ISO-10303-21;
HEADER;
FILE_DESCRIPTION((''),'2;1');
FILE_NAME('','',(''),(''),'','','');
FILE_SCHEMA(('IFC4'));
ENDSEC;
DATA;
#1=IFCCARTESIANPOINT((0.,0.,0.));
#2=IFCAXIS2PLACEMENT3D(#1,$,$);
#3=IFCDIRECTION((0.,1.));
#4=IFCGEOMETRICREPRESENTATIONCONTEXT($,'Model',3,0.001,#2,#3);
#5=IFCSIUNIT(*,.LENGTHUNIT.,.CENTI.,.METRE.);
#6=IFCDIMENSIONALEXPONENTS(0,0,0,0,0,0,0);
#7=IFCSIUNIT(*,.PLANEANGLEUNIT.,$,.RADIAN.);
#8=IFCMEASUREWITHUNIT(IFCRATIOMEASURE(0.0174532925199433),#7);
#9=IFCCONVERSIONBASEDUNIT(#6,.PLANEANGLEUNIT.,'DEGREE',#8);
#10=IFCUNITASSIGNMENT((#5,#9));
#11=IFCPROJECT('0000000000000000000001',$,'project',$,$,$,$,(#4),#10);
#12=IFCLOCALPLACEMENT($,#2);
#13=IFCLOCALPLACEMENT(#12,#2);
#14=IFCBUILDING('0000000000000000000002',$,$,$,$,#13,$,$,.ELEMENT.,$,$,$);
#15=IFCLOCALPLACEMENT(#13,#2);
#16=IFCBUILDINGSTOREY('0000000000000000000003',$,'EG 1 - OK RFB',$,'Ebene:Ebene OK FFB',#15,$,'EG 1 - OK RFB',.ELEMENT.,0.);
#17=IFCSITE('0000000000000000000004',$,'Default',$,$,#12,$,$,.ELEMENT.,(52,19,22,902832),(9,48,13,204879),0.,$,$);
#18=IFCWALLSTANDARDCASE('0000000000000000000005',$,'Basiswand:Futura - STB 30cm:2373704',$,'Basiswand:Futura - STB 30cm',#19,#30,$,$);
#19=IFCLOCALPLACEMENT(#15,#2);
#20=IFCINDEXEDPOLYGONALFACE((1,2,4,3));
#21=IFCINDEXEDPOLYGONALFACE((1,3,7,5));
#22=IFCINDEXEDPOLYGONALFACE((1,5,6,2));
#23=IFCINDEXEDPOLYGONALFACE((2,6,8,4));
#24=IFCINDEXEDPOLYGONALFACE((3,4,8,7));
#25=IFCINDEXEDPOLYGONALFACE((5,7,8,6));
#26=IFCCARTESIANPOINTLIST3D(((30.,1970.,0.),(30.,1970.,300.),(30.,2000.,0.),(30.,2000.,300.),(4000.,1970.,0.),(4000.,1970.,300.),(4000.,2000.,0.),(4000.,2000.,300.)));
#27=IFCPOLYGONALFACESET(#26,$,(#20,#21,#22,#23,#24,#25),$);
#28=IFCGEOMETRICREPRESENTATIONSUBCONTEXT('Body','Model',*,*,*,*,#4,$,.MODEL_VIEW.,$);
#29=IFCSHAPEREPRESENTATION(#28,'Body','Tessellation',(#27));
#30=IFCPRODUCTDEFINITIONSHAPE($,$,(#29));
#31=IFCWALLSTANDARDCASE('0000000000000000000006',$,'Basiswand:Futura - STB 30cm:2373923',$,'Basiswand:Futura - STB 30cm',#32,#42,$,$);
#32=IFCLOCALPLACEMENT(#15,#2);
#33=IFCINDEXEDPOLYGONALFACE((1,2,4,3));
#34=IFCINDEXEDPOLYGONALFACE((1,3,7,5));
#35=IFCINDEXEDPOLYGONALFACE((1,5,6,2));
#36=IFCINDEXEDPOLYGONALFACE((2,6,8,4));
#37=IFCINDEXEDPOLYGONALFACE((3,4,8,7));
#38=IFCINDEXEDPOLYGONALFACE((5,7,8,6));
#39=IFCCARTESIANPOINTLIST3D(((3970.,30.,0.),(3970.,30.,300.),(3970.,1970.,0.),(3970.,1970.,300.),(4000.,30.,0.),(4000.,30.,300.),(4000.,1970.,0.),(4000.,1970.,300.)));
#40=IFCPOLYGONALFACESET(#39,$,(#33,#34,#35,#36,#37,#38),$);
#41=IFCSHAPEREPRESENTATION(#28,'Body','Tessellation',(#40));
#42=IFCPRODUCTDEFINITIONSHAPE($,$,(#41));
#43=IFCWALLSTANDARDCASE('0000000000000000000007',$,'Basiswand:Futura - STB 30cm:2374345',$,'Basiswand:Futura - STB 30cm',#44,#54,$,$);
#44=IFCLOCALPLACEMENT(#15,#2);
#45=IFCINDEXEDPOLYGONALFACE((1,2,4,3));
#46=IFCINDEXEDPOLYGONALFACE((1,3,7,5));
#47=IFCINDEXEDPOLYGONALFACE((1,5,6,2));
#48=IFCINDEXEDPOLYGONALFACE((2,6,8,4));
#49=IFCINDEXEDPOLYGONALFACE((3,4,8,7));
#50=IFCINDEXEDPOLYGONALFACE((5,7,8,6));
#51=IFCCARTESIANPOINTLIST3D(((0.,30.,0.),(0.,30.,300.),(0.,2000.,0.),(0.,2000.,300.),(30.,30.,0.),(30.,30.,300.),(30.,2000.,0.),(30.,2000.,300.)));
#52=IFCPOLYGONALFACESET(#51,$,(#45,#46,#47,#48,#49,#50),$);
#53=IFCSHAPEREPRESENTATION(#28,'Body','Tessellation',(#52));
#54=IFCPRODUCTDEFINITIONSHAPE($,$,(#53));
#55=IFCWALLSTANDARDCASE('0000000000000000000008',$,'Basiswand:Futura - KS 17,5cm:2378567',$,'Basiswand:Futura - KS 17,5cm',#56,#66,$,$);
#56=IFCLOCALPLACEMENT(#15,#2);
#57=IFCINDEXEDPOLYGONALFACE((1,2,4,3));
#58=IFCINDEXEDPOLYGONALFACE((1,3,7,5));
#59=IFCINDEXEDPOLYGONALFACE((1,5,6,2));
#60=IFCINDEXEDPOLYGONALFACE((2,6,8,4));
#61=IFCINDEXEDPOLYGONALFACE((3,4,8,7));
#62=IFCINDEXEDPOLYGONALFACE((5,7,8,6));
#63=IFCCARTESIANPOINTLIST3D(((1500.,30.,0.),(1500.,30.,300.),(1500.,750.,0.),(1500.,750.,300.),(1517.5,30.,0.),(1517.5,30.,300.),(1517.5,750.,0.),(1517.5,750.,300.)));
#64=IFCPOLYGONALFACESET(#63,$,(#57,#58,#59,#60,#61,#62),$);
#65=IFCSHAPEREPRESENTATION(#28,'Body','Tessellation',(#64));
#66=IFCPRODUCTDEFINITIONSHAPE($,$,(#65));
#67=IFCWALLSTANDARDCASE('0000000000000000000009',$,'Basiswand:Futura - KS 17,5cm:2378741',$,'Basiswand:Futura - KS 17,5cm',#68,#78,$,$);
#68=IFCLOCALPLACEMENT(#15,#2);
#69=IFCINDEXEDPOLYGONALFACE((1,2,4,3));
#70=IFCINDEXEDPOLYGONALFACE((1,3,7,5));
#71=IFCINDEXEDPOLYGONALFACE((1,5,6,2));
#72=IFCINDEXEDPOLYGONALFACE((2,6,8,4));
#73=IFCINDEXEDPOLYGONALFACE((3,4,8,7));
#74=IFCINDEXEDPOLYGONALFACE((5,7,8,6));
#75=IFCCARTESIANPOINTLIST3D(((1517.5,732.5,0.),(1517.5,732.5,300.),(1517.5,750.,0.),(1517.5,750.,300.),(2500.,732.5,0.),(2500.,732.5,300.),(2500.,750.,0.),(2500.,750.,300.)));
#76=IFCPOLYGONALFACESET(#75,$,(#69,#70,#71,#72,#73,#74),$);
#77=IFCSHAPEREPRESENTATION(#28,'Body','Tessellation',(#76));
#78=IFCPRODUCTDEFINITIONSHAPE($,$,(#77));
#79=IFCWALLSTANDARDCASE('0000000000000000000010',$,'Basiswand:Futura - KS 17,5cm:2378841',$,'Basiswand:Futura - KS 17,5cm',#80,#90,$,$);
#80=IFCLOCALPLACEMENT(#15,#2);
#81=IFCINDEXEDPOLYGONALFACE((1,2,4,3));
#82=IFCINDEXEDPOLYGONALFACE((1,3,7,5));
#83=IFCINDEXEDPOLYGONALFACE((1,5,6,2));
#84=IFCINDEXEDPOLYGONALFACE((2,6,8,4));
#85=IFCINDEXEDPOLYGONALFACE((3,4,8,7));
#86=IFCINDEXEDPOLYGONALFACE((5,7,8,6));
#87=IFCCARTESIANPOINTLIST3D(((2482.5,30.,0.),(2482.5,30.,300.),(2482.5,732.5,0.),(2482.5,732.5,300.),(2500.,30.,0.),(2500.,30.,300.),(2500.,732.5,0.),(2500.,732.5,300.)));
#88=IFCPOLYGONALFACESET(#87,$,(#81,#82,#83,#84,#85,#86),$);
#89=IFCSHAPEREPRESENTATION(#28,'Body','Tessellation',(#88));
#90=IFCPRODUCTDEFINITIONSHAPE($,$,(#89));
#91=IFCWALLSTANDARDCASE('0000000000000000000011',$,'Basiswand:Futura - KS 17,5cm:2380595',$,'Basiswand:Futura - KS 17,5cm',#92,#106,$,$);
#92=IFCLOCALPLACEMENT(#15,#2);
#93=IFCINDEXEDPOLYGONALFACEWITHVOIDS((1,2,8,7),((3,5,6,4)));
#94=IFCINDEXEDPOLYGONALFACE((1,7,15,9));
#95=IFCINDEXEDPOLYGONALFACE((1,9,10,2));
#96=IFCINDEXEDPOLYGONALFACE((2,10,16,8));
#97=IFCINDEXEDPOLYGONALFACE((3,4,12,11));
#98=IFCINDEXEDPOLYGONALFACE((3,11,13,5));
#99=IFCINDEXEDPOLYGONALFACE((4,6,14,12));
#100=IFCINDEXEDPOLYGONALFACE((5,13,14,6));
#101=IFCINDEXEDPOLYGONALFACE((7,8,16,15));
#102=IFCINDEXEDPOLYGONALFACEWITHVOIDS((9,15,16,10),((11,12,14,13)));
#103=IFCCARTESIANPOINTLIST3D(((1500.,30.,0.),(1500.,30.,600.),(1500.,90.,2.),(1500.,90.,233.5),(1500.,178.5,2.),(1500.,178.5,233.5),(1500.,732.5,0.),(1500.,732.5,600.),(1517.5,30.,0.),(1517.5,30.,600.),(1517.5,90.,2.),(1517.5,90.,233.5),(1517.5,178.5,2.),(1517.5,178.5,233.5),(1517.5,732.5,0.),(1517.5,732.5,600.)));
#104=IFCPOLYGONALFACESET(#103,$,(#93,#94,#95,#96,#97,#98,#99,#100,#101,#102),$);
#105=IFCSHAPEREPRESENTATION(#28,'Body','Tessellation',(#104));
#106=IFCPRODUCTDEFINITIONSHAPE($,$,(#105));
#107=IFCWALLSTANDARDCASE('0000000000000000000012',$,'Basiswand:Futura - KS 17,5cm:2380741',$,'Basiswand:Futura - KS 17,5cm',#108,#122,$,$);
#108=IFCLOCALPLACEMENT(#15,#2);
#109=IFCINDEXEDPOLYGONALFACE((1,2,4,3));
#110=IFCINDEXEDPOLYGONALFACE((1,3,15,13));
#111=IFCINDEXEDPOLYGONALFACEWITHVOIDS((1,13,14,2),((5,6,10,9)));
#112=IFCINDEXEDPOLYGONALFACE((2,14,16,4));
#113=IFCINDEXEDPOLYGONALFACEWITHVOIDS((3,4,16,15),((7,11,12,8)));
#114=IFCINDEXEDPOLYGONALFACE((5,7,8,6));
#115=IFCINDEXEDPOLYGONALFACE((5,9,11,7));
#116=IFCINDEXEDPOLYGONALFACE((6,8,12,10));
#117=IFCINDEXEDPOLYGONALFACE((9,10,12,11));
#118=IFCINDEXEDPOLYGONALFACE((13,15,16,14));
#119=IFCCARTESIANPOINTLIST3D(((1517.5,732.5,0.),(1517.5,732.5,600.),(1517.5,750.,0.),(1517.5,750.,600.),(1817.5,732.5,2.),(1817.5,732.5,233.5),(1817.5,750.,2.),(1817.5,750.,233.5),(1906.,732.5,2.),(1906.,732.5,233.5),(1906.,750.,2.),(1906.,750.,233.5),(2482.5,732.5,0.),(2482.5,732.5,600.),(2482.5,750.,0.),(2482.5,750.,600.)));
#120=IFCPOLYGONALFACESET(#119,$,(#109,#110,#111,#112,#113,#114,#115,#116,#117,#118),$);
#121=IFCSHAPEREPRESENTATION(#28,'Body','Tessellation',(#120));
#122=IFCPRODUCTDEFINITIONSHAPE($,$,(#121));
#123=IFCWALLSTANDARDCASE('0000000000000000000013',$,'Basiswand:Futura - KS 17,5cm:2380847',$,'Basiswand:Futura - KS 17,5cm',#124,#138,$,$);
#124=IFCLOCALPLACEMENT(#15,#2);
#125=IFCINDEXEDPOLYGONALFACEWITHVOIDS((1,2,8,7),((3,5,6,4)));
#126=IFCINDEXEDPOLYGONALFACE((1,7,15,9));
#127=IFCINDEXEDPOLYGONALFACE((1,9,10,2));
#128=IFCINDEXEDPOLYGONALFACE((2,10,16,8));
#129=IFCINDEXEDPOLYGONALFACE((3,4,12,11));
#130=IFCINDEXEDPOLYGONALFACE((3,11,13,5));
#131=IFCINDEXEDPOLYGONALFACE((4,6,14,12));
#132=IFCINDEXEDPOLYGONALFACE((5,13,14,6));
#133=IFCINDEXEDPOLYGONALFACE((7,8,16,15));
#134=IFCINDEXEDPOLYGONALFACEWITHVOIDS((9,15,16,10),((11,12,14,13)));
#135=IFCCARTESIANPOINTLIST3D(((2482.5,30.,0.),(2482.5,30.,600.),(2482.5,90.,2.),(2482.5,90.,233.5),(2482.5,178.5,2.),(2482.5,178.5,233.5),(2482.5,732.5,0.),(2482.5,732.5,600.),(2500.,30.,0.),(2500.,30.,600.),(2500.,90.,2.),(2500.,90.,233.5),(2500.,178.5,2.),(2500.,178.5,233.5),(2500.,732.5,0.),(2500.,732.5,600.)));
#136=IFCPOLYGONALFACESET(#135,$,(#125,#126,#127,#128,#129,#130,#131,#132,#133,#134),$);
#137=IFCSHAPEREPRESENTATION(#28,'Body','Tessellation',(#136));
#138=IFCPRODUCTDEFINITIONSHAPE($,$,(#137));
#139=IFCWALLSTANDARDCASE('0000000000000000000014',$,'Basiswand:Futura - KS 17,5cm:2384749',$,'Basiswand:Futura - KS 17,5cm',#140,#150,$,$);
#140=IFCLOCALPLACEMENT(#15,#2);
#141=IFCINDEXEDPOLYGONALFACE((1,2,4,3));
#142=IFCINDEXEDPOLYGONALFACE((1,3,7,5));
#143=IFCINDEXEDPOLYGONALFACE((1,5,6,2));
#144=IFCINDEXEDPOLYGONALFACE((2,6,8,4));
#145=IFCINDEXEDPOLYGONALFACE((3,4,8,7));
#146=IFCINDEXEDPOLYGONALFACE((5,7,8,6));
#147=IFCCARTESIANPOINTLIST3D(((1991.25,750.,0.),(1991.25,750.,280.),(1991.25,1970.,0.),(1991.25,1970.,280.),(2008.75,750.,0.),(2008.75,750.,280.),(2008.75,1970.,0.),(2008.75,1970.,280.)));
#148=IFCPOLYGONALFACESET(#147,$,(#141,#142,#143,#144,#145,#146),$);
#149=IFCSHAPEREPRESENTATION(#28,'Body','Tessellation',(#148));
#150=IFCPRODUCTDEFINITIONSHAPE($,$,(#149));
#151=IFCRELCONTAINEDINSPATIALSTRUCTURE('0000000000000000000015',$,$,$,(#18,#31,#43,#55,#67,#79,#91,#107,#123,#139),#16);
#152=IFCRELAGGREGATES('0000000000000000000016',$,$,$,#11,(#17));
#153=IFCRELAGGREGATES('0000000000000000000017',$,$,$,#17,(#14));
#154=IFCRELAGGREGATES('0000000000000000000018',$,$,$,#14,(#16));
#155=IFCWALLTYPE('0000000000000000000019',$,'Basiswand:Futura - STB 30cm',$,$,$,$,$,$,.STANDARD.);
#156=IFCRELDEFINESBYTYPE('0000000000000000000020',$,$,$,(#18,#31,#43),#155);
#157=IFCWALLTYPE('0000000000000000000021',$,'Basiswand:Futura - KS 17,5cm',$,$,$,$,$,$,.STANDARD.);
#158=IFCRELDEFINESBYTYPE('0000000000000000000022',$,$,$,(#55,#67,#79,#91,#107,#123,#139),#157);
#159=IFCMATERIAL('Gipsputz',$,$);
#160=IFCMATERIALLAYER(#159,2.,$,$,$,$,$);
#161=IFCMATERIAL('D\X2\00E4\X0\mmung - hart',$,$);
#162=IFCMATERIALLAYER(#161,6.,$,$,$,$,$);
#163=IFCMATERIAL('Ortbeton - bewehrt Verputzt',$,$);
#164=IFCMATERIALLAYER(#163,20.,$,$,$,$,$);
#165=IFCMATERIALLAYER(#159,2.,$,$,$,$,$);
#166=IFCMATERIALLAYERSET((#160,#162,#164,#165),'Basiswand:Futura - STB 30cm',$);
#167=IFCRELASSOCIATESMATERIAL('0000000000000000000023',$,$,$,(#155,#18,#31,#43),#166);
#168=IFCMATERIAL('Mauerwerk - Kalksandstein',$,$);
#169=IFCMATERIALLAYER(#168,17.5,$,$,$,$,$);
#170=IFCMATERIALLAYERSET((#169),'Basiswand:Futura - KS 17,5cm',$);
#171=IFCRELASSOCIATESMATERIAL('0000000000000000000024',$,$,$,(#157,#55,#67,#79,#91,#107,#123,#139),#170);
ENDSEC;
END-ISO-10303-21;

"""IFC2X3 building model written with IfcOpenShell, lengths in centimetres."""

from ifc_helpers import new_model, entity, si_unit, converted_unit, direction, frame, frame_2d, origin, place, context, subcontext, project, spatial, rectangle, extrude, material, layer, layer_set, layer_usage, type_object, element, save


model = new_model("IFC2X3")

# Units and contexts
model_context = context("Model", 3, precision=0.001, world=origin(), true_north=direction((0.0, 1.0)))
body_context = subcontext(model_context, "Body", "Model", "MODEL_VIEW")
ifc_project = project(units=[si_unit("LENGTHUNIT", "METRE", prefix="CENTI"), converted_unit("PLANEANGLEUNIT", "DEGREE", entity("IfcRatioMeasure", 0.0174532925199433), si_unit("PLANEANGLEUNIT", "RADIAN"), dimensions=[0, 0, 0, 0, 0, 0, 0])], contexts=[model_context])

# Site, building, storey
site_placement = place(None, frame((0.0, 0.0, 0.0)))
site = spatial("IfcSite", under=ifc_project, at=site_placement, Name="Default", CompositionType="ELEMENT", RefLatitude=(52, 19, 22, 902832), RefLongitude=(9, 48, 13, 204879), RefElevation=0.0)
building_placement = place(site_placement, origin())
building = spatial("IfcBuilding", under=site, at=building_placement, CompositionType="ELEMENT")
storey_placement = place(building_placement, origin())
storey = spatial("IfcBuildingStorey", under=building, at=storey_placement, Name="EG 1 - OK RFB", ObjectType="Ebene:Ebene OK FFB", LongName="EG 1 - OK RFB", CompositionType="ELEMENT", Elevation=0.0)

# Walls
ifc_material_1 = material(Name="Gipsputz")
ifc_layer_1 = layer(ifc_material_1, 2.0)
ifc_material_2 = material(Name="Dämmung - hart")
ifc_layer_2 = layer(ifc_material_2, 6.0)
ifc_material_3 = material(Name="Ortbeton - bewehrt Verputzt")
ifc_layer_3 = layer(ifc_material_3, 20.0)
ifc_layer_4 = layer(ifc_material_1, 2.0)
ifc_layer_set_1 = layer_set([ifc_layer_1, ifc_layer_2, ifc_layer_3, ifc_layer_4], Name="Basiswand:Futura - STB 30cm")
ifc_layer_usage_1 = layer_usage(ifc_layer_set_1, "AXIS2", "NEGATIVE", 15.0)
wall_type_1 = type_object("IfcWallType", Name="Basiswand:Futura - STB 30cm", PredefinedType="STANDARD", material=ifc_layer_set_1)
wall_1_placement = place(storey_placement, frame((30.0, 1985.0, 0.0)))
element("IfcWallStandardCase", 1, at=wall_1_placement, inside=storey, type_object=wall_type_1, material=ifc_layer_usage_1, Name="Basiswand:Futura - STB 30cm:2373704", ObjectType="Basiswand:Futura - STB 30cm", context=body_context, shape_type="SweptSolid", body=[
    extrude(rectangle(XDim=3970.0, YDim=30.0, at=frame_2d((1985.0, 0.0), x_axis=(-1.0, 0.0))), origin(), (0.0, 0.0, 1.0), 300.0),
])
ifc_layer_usage_2 = layer_usage(ifc_layer_set_1, "AXIS2", "NEGATIVE", 15.0)
wall_2_placement = place(storey_placement, frame((3985.0, 1970.0, 0.0), z_axis=(0.0, 0.0, 1.0), x_axis=(0.0, -1.0, 0.0)))
element("IfcWallStandardCase", 2, at=wall_2_placement, inside=storey, type_object=wall_type_1, material=ifc_layer_usage_2, Name="Basiswand:Futura - STB 30cm:2373923", ObjectType="Basiswand:Futura - STB 30cm", context=body_context, shape_type="SweptSolid", body=[
    extrude(rectangle(XDim=1940.0, YDim=30.0, at=frame_2d((970.0, 0.0), x_axis=(-1.0, 0.0))), origin(), (0.0, 0.0, 1.0), 300.0),
])
ifc_layer_usage_3 = layer_usage(ifc_layer_set_1, "AXIS2", "NEGATIVE", 15.0)
wall_3_placement = place(storey_placement, frame((15.0, 30.0, 0.0), z_axis=(0.0, 0.0, 1.0), x_axis=(0.0, 1.0, 0.0)))
element("IfcWallStandardCase", 3, at=wall_3_placement, inside=storey, type_object=wall_type_1, material=ifc_layer_usage_3, Name="Basiswand:Futura - STB 30cm:2374345", ObjectType="Basiswand:Futura - STB 30cm", context=body_context, shape_type="SweptSolid", body=[
    extrude(rectangle(XDim=1970.0, YDim=30.0, at=frame_2d((985.0, 0.0), x_axis=(-1.0, 0.0))), origin(), (0.0, 0.0, 1.0), 300.0),
])
ifc_material_4 = material(Name="Mauerwerk - Kalksandstein")
ifc_layer_5 = layer(ifc_material_4, 17.5)
ifc_layer_set_2 = layer_set([ifc_layer_5], Name="Basiswand:Futura - KS 17,5cm")
ifc_layer_usage_4 = layer_usage(ifc_layer_set_2, "AXIS2", "NEGATIVE", 8.75)
wall_type_2 = type_object("IfcWallType", Name="Basiswand:Futura - KS 17,5cm", PredefinedType="STANDARD", material=ifc_layer_set_2)
wall_4_placement = place(storey_placement, frame((1508.75, 30.0, 0.0), z_axis=(0.0, 0.0, 1.0), x_axis=(0.0, 1.0, 0.0)))
element("IfcWallStandardCase", 4, at=wall_4_placement, inside=storey, type_object=wall_type_2, material=ifc_layer_usage_4, Name="Basiswand:Futura - KS 17,5cm:2378567", ObjectType="Basiswand:Futura - KS 17,5cm", context=body_context, shape_type="SweptSolid", body=[
    extrude(rectangle(XDim=720.0, YDim=17.5, at=frame_2d((360.0, 0.0), x_axis=(-1.0, 0.0))), origin(), (0.0, 0.0, 1.0), 300.0),
])
ifc_layer_usage_5 = layer_usage(ifc_layer_set_2, "AXIS2", "NEGATIVE", 8.75)
wall_5_placement = place(storey_placement, frame((1517.5, 741.25, 0.0)))
element("IfcWallStandardCase", 5, at=wall_5_placement, inside=storey, type_object=wall_type_2, material=ifc_layer_usage_5, Name="Basiswand:Futura - KS 17,5cm:2378741", ObjectType="Basiswand:Futura - KS 17,5cm", context=body_context, shape_type="SweptSolid", body=[
    extrude(rectangle(XDim=982.5, YDim=17.5, at=frame_2d((491.25, 0.0), x_axis=(-1.0, 0.0))), origin(), (0.0, 0.0, 1.0), 300.0),
])
ifc_layer_usage_6 = layer_usage(ifc_layer_set_2, "AXIS2", "NEGATIVE", 8.75)
wall_6_placement = place(storey_placement, frame((2491.25, 732.5, 0.0), z_axis=(0.0, 0.0, 1.0), x_axis=(0.0, -1.0, 0.0)))
element("IfcWallStandardCase", 6, at=wall_6_placement, inside=storey, type_object=wall_type_2, material=ifc_layer_usage_6, Name="Basiswand:Futura - KS 17,5cm:2378841", ObjectType="Basiswand:Futura - KS 17,5cm", context=body_context, shape_type="SweptSolid", body=[
    extrude(rectangle(XDim=702.5, YDim=17.5, at=frame_2d((351.25, 0.0), x_axis=(-1.0, 0.0))), origin(), (0.0, 0.0, 1.0), 300.0),
])

# Walls, openings
ifc_layer_usage_7 = layer_usage(ifc_layer_set_2, "AXIS2", "NEGATIVE", 8.75)
wall_7_placement = place(storey_placement, frame((1508.75, 30.0, 0.0), z_axis=(0.0, 0.0, 1.0), x_axis=(0.0, 1.0, 0.0)))
wall_7 = element("IfcWallStandardCase", 7, at=wall_7_placement, inside=storey, type_object=wall_type_2, material=ifc_layer_usage_7, Name="Basiswand:Futura - KS 17,5cm:2380595", ObjectType="Basiswand:Futura - KS 17,5cm", context=body_context, shape_type="SweptSolid", body=[
    extrude(rectangle(XDim=702.5, YDim=17.5, at=frame_2d((351.25, 0.0), x_axis=(-1.0, 0.0))), origin(), (0.0, 0.0, 1.0), 600.0),
])
opening_1_placement = place(wall_7_placement, frame((60.0, -8.75, 2.0)))
element("IfcOpeningElement", 8, at=opening_1_placement, cuts=wall_7, ObjectType="Opening", context=body_context, shape_type="SweptSolid", body=[
    extrude(rectangle(XDim=231.5, YDim=88.5, at=frame_2d((115.75, 44.25), x_axis=(-1.0, 0.0))), frame((0.0, 0.0, 0.0), z_axis=(0.0, 1.0, 0.0), x_axis=(0.0, 0.0, 1.0)), (0.0, 0.0, 1.0), 17.5),
])
ifc_layer_usage_8 = layer_usage(ifc_layer_set_2, "AXIS2", "NEGATIVE", 8.75)
wall_8_placement = place(storey_placement, frame((1500.0, 741.25, 0.0)))
wall_8 = element("IfcWallStandardCase", 9, at=wall_8_placement, inside=storey, type_object=wall_type_2, material=ifc_layer_usage_8, Name="Basiswand:Futura - KS 17,5cm:2380741", ObjectType="Basiswand:Futura - KS 17,5cm", context=body_context, shape_type="SweptSolid", body=[
    extrude(rectangle(XDim=965.0, YDim=17.5, at=frame_2d((500.0, 0.0), x_axis=(-1.0, 0.0))), origin(), (0.0, 0.0, 1.0), 600.0),
])
opening_2_placement = place(wall_8_placement, frame((317.5, -8.75, 2.0)))
element("IfcOpeningElement", 10, at=opening_2_placement, cuts=wall_8, ObjectType="Opening", context=body_context, shape_type="SweptSolid", body=[
    extrude(rectangle(XDim=231.5, YDim=88.5, at=frame_2d((115.75, 44.25), x_axis=(-1.0, 0.0))), frame((0.0, 0.0, 0.0), z_axis=(0.0, 1.0, 0.0), x_axis=(0.0, 0.0, 1.0)), (0.0, 0.0, 1.0), 17.5),
])
ifc_layer_usage_9 = layer_usage(ifc_layer_set_2, "AXIS2", "NEGATIVE", 8.75)
wall_9_placement = place(storey_placement, frame((2491.25, 750.0, 0.0), z_axis=(0.0, 0.0, 1.0), x_axis=(0.0, -1.0, 0.0)))
wall_9 = element("IfcWallStandardCase", 11, at=wall_9_placement, inside=storey, type_object=wall_type_2, material=ifc_layer_usage_9, Name="Basiswand:Futura - KS 17,5cm:2380847", ObjectType="Basiswand:Futura - KS 17,5cm", context=body_context, shape_type="SweptSolid", body=[
    extrude(rectangle(XDim=702.5, YDim=17.5, at=frame_2d((368.75, 0.0), x_axis=(-1.0, 0.0))), origin(), (0.0, 0.0, 1.0), 600.0),
])
opening_3_placement = place(wall_9_placement, frame((571.5, -8.75, 2.0)))
element("IfcOpeningElement", 12, at=opening_3_placement, cuts=wall_9, ObjectType="Opening", context=body_context, shape_type="SweptSolid", body=[
    extrude(rectangle(XDim=231.5, YDim=88.5, at=frame_2d((115.75, 44.25), x_axis=(-1.0, 0.0))), frame((0.0, 0.0, 0.0), z_axis=(0.0, 1.0, 0.0), x_axis=(0.0, 0.0, 1.0)), (0.0, 0.0, 1.0), 17.5),
])

# Wall
ifc_layer_usage_10 = layer_usage(ifc_layer_set_2, "AXIS2", "NEGATIVE", 8.75)
wall_10_placement = place(storey_placement, frame((2000.0, 1970.0, 0.0), z_axis=(0.0, 0.0, 1.0), x_axis=(0.0, -1.0, 0.0)))
element("IfcWallStandardCase", 13, at=wall_10_placement, inside=storey, type_object=wall_type_2, material=ifc_layer_usage_10, Name="Basiswand:Futura - KS 17,5cm:2384749", ObjectType="Basiswand:Futura - KS 17,5cm", context=body_context, shape_type="SweptSolid", body=[
    extrude(rectangle(XDim=1220.0, YDim=17.5, at=frame_2d((610.0, 0.0), x_axis=(-1.0, 0.0))), origin(), (0.0, 0.0, 1.0), 280.0),
])

save(model, "model.ifc")
